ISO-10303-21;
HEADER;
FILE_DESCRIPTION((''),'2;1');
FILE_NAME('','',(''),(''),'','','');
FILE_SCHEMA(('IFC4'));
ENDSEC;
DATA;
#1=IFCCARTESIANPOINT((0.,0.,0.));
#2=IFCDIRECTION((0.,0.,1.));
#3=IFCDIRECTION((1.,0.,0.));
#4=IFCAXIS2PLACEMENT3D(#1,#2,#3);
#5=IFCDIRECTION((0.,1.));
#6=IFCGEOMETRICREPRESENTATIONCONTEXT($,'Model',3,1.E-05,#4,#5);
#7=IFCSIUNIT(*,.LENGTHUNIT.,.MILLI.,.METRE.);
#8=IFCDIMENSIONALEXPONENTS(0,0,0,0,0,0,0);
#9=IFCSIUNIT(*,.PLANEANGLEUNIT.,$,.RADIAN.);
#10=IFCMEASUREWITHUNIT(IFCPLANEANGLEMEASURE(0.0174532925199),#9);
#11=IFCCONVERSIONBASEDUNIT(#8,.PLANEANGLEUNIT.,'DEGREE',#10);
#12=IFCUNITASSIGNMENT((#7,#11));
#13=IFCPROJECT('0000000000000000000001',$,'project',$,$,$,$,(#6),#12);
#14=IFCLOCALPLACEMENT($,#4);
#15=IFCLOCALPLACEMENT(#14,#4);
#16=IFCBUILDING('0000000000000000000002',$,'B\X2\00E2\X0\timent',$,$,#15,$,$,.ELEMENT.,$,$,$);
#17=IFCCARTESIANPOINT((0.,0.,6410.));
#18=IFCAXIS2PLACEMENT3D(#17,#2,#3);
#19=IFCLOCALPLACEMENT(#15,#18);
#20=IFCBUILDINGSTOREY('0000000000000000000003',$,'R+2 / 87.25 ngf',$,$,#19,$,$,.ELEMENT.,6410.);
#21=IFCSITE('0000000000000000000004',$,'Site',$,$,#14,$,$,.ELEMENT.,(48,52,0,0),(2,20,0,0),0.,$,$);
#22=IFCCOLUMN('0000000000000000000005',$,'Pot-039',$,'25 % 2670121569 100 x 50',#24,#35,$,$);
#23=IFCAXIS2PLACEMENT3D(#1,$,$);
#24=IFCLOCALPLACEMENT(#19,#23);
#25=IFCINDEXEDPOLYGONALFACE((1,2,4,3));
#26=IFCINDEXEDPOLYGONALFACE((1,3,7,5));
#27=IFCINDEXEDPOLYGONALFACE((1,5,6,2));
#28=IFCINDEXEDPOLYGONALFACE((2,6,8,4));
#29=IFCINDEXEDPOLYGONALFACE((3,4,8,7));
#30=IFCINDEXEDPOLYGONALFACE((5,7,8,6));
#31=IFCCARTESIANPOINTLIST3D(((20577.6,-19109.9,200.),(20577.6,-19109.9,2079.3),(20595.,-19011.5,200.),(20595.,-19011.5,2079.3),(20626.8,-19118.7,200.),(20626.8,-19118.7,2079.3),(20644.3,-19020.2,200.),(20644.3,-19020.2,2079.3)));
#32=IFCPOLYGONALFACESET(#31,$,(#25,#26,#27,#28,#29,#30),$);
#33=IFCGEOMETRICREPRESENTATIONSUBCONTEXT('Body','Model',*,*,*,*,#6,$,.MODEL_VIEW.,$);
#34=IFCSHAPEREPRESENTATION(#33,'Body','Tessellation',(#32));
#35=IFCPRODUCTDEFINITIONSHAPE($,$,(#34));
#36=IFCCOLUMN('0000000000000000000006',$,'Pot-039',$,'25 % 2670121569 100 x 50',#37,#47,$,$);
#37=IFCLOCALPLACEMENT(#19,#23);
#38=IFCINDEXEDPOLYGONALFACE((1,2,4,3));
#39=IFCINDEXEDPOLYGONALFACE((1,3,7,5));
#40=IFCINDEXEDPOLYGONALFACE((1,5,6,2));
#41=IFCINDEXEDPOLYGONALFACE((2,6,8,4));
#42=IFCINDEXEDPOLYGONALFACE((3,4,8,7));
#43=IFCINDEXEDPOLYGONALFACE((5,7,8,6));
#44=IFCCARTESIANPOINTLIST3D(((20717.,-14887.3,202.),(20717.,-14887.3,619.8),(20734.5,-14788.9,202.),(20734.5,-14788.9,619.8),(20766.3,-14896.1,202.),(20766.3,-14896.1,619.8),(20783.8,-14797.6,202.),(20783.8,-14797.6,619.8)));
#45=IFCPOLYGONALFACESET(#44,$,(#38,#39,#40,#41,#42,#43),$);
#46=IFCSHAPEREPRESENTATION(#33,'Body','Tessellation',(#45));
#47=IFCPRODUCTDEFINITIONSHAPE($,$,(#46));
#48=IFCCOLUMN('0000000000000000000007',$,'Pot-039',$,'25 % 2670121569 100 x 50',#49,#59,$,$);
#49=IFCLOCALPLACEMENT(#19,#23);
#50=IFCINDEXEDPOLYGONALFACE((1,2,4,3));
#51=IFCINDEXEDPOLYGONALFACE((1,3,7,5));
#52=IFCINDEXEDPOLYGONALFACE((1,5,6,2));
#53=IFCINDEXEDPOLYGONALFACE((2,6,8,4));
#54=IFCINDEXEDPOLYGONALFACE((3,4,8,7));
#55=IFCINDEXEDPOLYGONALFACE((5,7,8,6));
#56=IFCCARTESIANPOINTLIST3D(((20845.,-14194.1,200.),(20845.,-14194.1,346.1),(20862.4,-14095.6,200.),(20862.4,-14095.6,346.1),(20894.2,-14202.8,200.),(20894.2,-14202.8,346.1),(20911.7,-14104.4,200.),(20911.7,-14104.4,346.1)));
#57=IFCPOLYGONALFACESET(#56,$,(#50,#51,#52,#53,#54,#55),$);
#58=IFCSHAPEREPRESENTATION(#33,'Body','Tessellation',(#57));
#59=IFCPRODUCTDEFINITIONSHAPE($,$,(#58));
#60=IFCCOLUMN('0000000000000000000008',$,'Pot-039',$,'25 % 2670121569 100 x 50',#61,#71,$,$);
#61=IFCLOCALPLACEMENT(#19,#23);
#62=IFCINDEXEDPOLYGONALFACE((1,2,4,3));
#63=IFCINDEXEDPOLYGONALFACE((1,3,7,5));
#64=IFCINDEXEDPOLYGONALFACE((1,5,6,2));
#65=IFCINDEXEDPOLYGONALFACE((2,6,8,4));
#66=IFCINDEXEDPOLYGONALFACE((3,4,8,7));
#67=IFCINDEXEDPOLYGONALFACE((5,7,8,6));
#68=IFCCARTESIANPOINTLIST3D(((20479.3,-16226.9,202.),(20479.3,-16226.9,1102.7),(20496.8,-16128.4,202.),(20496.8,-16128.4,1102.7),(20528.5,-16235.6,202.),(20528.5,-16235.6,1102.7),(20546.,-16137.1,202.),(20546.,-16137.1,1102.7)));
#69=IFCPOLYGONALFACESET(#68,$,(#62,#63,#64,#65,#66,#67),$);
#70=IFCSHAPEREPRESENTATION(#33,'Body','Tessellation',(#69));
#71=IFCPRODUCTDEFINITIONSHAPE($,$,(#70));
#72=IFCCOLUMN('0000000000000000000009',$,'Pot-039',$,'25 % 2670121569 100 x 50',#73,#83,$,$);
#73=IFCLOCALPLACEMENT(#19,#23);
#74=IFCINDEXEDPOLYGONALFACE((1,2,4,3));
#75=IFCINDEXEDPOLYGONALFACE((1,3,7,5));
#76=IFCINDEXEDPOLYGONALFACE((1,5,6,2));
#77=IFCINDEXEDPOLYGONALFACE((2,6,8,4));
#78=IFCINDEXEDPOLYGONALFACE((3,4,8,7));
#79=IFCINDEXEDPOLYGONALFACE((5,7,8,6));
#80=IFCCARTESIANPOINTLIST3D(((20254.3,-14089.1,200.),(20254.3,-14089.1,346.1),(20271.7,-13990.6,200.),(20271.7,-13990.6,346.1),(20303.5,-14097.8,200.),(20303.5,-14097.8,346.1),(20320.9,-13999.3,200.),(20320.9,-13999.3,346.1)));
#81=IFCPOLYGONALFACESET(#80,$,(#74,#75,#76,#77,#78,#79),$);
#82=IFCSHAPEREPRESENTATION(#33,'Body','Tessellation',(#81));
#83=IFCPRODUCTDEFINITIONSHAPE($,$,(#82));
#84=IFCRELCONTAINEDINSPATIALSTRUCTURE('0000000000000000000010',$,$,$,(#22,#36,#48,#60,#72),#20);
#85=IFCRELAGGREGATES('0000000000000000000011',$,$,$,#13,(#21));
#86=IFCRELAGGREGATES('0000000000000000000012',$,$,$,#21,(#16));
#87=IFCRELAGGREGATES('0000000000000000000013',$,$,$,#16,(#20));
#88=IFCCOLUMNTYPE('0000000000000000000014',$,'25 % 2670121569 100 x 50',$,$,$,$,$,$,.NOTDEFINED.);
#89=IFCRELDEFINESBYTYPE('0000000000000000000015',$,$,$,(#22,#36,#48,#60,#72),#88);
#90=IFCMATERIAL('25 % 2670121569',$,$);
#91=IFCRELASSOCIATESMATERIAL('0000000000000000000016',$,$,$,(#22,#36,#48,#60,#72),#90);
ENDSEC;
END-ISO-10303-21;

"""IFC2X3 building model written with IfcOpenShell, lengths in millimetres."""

from ifc_helpers import new_model, entity, si_unit, converted_unit, direction, frame, origin_with_axes, origin_2d_with_axis, place, context, subcontext, project, spatial, rectangle, extrude, material, type_object, element, save


model = new_model("IFC2X3")

# Units and contexts
model_context = context("Model", 3, precision=1e-05, world=origin_with_axes(), true_north=direction((0.0, 1.0)))
body_context = subcontext(model_context, "Body", "Model", "MODEL_VIEW")
ifc_project = project(units=[si_unit("LENGTHUNIT", "METRE", prefix="MILLI"), converted_unit("PLANEANGLEUNIT", "DEGREE", entity("IfcPlaneAngleMeasure", 0.0174532925199), si_unit("PLANEANGLEUNIT", "RADIAN"), dimensions=[0, 0, 0, 0, 0, 0, 0])], contexts=[model_context])

# Site, building, storey
site_placement = place(None, origin_with_axes())
site = spatial("IfcSite", under=ifc_project, at=site_placement, Name="Site", CompositionType="ELEMENT", RefLatitude=(48, 52, 0, 0), RefLongitude=(2, 20, 0, 0), RefElevation=0.0)
building_placement = place(site_placement, origin_with_axes())
building = spatial("IfcBuilding", under=site, at=building_placement, Name="Bâtiment", CompositionType="ELEMENT")
storey_placement = place(building_placement, frame((0.0, 0.0, 6410.0), z_axis=(0.0, 0.0, 1.0), x_axis=(1.0, 0.0, 0.0)))
storey = spatial("IfcBuildingStorey", under=building, at=storey_placement, Name="R+2 / 87.25 ngf", CompositionType="ELEMENT", Elevation=6410.0)

# Columns
ifc_material_1 = material(Name="25 % 2670121569")
column_type = type_object("IfcColumnType", Name="25 % 2670121569 100 x 50", PredefinedType="NOTDEFINED")
column_1_placement = place(storey_placement, frame((20610.9, -19065.1, 200.0), z_axis=(0.0, 0.0, 1.0), x_axis=(0.17478, 0.984607, 0.0)))
element("IfcColumn", 1, at=column_1_placement, inside=storey, type_object=column_type, material=ifc_material_1, Name="Pot-039", ObjectType="25 % 2670121569 100 x 50", context=body_context, shape_type="SweptSolid", body=[
    extrude(rectangle(XDim=100.0, YDim=50.0, at=origin_2d_with_axis()), origin_with_axes(), (0.0, 0.0, 1.0), 1879.3),
])
column_2_placement = place(storey_placement, frame((20750.4, -14842.5, 202.0), z_axis=(0.0, 0.0, 1.0), x_axis=(0.17478, 0.984607, 0.0)))
element("IfcColumn", 2, at=column_2_placement, inside=storey, type_object=column_type, material=ifc_material_1, Name="Pot-039", ObjectType="25 % 2670121569 100 x 50", context=body_context, shape_type="SweptSolid", body=[
    extrude(rectangle(XDim=100.0, YDim=50.0, at=origin_2d_with_axis()), origin_with_axes(), (0.0, 0.0, 1.0), 417.8),
])
column_3_placement = place(storey_placement, frame((20878.3, -14149.2, 200.0), z_axis=(0.0, 0.0, 1.0), x_axis=(0.174407, 0.984674, 0.0)))
element("IfcColumn", 3, at=column_3_placement, inside=storey, type_object=column_type, material=ifc_material_1, Name="Pot-039", ObjectType="25 % 2670121569 100 x 50", context=body_context, shape_type="SweptSolid", body=[
    extrude(rectangle(XDim=100.0, YDim=50.0, at=origin_2d_with_axis()), origin_with_axes(), (0.0, 0.0, 1.0), 146.1),
])
column_4_placement = place(storey_placement, frame((20512.6, -16182.0, 202.0), z_axis=(0.0, 0.0, 1.0), x_axis=(0.17478, 0.984607, 0.0)))
element("IfcColumn", 4, at=column_4_placement, inside=storey, type_object=column_type, material=ifc_material_1, Name="Pot-039", ObjectType="25 % 2670121569 100 x 50", context=body_context, shape_type="SweptSolid", body=[
    extrude(rectangle(XDim=100.0, YDim=50.0, at=origin_2d_with_axis()), origin_with_axes(), (0.0, 0.0, 1.0), 900.7),
])
column_5_placement = place(storey_placement, frame((20287.6, -14044.2, 200.0), z_axis=(0.0, 0.0, 1.0), x_axis=(0.174407, 0.984674, 0.0)))
element("IfcColumn", 5, at=column_5_placement, inside=storey, type_object=column_type, material=ifc_material_1, Name="Pot-039", ObjectType="25 % 2670121569 100 x 50", context=body_context, shape_type="SweptSolid", body=[
    extrude(rectangle(XDim=100.0, YDim=50.0, at=origin_2d_with_axis()), origin_with_axes(), (0.0, 0.0, 1.0), 146.1),
])

save(model, "model.ifc")
